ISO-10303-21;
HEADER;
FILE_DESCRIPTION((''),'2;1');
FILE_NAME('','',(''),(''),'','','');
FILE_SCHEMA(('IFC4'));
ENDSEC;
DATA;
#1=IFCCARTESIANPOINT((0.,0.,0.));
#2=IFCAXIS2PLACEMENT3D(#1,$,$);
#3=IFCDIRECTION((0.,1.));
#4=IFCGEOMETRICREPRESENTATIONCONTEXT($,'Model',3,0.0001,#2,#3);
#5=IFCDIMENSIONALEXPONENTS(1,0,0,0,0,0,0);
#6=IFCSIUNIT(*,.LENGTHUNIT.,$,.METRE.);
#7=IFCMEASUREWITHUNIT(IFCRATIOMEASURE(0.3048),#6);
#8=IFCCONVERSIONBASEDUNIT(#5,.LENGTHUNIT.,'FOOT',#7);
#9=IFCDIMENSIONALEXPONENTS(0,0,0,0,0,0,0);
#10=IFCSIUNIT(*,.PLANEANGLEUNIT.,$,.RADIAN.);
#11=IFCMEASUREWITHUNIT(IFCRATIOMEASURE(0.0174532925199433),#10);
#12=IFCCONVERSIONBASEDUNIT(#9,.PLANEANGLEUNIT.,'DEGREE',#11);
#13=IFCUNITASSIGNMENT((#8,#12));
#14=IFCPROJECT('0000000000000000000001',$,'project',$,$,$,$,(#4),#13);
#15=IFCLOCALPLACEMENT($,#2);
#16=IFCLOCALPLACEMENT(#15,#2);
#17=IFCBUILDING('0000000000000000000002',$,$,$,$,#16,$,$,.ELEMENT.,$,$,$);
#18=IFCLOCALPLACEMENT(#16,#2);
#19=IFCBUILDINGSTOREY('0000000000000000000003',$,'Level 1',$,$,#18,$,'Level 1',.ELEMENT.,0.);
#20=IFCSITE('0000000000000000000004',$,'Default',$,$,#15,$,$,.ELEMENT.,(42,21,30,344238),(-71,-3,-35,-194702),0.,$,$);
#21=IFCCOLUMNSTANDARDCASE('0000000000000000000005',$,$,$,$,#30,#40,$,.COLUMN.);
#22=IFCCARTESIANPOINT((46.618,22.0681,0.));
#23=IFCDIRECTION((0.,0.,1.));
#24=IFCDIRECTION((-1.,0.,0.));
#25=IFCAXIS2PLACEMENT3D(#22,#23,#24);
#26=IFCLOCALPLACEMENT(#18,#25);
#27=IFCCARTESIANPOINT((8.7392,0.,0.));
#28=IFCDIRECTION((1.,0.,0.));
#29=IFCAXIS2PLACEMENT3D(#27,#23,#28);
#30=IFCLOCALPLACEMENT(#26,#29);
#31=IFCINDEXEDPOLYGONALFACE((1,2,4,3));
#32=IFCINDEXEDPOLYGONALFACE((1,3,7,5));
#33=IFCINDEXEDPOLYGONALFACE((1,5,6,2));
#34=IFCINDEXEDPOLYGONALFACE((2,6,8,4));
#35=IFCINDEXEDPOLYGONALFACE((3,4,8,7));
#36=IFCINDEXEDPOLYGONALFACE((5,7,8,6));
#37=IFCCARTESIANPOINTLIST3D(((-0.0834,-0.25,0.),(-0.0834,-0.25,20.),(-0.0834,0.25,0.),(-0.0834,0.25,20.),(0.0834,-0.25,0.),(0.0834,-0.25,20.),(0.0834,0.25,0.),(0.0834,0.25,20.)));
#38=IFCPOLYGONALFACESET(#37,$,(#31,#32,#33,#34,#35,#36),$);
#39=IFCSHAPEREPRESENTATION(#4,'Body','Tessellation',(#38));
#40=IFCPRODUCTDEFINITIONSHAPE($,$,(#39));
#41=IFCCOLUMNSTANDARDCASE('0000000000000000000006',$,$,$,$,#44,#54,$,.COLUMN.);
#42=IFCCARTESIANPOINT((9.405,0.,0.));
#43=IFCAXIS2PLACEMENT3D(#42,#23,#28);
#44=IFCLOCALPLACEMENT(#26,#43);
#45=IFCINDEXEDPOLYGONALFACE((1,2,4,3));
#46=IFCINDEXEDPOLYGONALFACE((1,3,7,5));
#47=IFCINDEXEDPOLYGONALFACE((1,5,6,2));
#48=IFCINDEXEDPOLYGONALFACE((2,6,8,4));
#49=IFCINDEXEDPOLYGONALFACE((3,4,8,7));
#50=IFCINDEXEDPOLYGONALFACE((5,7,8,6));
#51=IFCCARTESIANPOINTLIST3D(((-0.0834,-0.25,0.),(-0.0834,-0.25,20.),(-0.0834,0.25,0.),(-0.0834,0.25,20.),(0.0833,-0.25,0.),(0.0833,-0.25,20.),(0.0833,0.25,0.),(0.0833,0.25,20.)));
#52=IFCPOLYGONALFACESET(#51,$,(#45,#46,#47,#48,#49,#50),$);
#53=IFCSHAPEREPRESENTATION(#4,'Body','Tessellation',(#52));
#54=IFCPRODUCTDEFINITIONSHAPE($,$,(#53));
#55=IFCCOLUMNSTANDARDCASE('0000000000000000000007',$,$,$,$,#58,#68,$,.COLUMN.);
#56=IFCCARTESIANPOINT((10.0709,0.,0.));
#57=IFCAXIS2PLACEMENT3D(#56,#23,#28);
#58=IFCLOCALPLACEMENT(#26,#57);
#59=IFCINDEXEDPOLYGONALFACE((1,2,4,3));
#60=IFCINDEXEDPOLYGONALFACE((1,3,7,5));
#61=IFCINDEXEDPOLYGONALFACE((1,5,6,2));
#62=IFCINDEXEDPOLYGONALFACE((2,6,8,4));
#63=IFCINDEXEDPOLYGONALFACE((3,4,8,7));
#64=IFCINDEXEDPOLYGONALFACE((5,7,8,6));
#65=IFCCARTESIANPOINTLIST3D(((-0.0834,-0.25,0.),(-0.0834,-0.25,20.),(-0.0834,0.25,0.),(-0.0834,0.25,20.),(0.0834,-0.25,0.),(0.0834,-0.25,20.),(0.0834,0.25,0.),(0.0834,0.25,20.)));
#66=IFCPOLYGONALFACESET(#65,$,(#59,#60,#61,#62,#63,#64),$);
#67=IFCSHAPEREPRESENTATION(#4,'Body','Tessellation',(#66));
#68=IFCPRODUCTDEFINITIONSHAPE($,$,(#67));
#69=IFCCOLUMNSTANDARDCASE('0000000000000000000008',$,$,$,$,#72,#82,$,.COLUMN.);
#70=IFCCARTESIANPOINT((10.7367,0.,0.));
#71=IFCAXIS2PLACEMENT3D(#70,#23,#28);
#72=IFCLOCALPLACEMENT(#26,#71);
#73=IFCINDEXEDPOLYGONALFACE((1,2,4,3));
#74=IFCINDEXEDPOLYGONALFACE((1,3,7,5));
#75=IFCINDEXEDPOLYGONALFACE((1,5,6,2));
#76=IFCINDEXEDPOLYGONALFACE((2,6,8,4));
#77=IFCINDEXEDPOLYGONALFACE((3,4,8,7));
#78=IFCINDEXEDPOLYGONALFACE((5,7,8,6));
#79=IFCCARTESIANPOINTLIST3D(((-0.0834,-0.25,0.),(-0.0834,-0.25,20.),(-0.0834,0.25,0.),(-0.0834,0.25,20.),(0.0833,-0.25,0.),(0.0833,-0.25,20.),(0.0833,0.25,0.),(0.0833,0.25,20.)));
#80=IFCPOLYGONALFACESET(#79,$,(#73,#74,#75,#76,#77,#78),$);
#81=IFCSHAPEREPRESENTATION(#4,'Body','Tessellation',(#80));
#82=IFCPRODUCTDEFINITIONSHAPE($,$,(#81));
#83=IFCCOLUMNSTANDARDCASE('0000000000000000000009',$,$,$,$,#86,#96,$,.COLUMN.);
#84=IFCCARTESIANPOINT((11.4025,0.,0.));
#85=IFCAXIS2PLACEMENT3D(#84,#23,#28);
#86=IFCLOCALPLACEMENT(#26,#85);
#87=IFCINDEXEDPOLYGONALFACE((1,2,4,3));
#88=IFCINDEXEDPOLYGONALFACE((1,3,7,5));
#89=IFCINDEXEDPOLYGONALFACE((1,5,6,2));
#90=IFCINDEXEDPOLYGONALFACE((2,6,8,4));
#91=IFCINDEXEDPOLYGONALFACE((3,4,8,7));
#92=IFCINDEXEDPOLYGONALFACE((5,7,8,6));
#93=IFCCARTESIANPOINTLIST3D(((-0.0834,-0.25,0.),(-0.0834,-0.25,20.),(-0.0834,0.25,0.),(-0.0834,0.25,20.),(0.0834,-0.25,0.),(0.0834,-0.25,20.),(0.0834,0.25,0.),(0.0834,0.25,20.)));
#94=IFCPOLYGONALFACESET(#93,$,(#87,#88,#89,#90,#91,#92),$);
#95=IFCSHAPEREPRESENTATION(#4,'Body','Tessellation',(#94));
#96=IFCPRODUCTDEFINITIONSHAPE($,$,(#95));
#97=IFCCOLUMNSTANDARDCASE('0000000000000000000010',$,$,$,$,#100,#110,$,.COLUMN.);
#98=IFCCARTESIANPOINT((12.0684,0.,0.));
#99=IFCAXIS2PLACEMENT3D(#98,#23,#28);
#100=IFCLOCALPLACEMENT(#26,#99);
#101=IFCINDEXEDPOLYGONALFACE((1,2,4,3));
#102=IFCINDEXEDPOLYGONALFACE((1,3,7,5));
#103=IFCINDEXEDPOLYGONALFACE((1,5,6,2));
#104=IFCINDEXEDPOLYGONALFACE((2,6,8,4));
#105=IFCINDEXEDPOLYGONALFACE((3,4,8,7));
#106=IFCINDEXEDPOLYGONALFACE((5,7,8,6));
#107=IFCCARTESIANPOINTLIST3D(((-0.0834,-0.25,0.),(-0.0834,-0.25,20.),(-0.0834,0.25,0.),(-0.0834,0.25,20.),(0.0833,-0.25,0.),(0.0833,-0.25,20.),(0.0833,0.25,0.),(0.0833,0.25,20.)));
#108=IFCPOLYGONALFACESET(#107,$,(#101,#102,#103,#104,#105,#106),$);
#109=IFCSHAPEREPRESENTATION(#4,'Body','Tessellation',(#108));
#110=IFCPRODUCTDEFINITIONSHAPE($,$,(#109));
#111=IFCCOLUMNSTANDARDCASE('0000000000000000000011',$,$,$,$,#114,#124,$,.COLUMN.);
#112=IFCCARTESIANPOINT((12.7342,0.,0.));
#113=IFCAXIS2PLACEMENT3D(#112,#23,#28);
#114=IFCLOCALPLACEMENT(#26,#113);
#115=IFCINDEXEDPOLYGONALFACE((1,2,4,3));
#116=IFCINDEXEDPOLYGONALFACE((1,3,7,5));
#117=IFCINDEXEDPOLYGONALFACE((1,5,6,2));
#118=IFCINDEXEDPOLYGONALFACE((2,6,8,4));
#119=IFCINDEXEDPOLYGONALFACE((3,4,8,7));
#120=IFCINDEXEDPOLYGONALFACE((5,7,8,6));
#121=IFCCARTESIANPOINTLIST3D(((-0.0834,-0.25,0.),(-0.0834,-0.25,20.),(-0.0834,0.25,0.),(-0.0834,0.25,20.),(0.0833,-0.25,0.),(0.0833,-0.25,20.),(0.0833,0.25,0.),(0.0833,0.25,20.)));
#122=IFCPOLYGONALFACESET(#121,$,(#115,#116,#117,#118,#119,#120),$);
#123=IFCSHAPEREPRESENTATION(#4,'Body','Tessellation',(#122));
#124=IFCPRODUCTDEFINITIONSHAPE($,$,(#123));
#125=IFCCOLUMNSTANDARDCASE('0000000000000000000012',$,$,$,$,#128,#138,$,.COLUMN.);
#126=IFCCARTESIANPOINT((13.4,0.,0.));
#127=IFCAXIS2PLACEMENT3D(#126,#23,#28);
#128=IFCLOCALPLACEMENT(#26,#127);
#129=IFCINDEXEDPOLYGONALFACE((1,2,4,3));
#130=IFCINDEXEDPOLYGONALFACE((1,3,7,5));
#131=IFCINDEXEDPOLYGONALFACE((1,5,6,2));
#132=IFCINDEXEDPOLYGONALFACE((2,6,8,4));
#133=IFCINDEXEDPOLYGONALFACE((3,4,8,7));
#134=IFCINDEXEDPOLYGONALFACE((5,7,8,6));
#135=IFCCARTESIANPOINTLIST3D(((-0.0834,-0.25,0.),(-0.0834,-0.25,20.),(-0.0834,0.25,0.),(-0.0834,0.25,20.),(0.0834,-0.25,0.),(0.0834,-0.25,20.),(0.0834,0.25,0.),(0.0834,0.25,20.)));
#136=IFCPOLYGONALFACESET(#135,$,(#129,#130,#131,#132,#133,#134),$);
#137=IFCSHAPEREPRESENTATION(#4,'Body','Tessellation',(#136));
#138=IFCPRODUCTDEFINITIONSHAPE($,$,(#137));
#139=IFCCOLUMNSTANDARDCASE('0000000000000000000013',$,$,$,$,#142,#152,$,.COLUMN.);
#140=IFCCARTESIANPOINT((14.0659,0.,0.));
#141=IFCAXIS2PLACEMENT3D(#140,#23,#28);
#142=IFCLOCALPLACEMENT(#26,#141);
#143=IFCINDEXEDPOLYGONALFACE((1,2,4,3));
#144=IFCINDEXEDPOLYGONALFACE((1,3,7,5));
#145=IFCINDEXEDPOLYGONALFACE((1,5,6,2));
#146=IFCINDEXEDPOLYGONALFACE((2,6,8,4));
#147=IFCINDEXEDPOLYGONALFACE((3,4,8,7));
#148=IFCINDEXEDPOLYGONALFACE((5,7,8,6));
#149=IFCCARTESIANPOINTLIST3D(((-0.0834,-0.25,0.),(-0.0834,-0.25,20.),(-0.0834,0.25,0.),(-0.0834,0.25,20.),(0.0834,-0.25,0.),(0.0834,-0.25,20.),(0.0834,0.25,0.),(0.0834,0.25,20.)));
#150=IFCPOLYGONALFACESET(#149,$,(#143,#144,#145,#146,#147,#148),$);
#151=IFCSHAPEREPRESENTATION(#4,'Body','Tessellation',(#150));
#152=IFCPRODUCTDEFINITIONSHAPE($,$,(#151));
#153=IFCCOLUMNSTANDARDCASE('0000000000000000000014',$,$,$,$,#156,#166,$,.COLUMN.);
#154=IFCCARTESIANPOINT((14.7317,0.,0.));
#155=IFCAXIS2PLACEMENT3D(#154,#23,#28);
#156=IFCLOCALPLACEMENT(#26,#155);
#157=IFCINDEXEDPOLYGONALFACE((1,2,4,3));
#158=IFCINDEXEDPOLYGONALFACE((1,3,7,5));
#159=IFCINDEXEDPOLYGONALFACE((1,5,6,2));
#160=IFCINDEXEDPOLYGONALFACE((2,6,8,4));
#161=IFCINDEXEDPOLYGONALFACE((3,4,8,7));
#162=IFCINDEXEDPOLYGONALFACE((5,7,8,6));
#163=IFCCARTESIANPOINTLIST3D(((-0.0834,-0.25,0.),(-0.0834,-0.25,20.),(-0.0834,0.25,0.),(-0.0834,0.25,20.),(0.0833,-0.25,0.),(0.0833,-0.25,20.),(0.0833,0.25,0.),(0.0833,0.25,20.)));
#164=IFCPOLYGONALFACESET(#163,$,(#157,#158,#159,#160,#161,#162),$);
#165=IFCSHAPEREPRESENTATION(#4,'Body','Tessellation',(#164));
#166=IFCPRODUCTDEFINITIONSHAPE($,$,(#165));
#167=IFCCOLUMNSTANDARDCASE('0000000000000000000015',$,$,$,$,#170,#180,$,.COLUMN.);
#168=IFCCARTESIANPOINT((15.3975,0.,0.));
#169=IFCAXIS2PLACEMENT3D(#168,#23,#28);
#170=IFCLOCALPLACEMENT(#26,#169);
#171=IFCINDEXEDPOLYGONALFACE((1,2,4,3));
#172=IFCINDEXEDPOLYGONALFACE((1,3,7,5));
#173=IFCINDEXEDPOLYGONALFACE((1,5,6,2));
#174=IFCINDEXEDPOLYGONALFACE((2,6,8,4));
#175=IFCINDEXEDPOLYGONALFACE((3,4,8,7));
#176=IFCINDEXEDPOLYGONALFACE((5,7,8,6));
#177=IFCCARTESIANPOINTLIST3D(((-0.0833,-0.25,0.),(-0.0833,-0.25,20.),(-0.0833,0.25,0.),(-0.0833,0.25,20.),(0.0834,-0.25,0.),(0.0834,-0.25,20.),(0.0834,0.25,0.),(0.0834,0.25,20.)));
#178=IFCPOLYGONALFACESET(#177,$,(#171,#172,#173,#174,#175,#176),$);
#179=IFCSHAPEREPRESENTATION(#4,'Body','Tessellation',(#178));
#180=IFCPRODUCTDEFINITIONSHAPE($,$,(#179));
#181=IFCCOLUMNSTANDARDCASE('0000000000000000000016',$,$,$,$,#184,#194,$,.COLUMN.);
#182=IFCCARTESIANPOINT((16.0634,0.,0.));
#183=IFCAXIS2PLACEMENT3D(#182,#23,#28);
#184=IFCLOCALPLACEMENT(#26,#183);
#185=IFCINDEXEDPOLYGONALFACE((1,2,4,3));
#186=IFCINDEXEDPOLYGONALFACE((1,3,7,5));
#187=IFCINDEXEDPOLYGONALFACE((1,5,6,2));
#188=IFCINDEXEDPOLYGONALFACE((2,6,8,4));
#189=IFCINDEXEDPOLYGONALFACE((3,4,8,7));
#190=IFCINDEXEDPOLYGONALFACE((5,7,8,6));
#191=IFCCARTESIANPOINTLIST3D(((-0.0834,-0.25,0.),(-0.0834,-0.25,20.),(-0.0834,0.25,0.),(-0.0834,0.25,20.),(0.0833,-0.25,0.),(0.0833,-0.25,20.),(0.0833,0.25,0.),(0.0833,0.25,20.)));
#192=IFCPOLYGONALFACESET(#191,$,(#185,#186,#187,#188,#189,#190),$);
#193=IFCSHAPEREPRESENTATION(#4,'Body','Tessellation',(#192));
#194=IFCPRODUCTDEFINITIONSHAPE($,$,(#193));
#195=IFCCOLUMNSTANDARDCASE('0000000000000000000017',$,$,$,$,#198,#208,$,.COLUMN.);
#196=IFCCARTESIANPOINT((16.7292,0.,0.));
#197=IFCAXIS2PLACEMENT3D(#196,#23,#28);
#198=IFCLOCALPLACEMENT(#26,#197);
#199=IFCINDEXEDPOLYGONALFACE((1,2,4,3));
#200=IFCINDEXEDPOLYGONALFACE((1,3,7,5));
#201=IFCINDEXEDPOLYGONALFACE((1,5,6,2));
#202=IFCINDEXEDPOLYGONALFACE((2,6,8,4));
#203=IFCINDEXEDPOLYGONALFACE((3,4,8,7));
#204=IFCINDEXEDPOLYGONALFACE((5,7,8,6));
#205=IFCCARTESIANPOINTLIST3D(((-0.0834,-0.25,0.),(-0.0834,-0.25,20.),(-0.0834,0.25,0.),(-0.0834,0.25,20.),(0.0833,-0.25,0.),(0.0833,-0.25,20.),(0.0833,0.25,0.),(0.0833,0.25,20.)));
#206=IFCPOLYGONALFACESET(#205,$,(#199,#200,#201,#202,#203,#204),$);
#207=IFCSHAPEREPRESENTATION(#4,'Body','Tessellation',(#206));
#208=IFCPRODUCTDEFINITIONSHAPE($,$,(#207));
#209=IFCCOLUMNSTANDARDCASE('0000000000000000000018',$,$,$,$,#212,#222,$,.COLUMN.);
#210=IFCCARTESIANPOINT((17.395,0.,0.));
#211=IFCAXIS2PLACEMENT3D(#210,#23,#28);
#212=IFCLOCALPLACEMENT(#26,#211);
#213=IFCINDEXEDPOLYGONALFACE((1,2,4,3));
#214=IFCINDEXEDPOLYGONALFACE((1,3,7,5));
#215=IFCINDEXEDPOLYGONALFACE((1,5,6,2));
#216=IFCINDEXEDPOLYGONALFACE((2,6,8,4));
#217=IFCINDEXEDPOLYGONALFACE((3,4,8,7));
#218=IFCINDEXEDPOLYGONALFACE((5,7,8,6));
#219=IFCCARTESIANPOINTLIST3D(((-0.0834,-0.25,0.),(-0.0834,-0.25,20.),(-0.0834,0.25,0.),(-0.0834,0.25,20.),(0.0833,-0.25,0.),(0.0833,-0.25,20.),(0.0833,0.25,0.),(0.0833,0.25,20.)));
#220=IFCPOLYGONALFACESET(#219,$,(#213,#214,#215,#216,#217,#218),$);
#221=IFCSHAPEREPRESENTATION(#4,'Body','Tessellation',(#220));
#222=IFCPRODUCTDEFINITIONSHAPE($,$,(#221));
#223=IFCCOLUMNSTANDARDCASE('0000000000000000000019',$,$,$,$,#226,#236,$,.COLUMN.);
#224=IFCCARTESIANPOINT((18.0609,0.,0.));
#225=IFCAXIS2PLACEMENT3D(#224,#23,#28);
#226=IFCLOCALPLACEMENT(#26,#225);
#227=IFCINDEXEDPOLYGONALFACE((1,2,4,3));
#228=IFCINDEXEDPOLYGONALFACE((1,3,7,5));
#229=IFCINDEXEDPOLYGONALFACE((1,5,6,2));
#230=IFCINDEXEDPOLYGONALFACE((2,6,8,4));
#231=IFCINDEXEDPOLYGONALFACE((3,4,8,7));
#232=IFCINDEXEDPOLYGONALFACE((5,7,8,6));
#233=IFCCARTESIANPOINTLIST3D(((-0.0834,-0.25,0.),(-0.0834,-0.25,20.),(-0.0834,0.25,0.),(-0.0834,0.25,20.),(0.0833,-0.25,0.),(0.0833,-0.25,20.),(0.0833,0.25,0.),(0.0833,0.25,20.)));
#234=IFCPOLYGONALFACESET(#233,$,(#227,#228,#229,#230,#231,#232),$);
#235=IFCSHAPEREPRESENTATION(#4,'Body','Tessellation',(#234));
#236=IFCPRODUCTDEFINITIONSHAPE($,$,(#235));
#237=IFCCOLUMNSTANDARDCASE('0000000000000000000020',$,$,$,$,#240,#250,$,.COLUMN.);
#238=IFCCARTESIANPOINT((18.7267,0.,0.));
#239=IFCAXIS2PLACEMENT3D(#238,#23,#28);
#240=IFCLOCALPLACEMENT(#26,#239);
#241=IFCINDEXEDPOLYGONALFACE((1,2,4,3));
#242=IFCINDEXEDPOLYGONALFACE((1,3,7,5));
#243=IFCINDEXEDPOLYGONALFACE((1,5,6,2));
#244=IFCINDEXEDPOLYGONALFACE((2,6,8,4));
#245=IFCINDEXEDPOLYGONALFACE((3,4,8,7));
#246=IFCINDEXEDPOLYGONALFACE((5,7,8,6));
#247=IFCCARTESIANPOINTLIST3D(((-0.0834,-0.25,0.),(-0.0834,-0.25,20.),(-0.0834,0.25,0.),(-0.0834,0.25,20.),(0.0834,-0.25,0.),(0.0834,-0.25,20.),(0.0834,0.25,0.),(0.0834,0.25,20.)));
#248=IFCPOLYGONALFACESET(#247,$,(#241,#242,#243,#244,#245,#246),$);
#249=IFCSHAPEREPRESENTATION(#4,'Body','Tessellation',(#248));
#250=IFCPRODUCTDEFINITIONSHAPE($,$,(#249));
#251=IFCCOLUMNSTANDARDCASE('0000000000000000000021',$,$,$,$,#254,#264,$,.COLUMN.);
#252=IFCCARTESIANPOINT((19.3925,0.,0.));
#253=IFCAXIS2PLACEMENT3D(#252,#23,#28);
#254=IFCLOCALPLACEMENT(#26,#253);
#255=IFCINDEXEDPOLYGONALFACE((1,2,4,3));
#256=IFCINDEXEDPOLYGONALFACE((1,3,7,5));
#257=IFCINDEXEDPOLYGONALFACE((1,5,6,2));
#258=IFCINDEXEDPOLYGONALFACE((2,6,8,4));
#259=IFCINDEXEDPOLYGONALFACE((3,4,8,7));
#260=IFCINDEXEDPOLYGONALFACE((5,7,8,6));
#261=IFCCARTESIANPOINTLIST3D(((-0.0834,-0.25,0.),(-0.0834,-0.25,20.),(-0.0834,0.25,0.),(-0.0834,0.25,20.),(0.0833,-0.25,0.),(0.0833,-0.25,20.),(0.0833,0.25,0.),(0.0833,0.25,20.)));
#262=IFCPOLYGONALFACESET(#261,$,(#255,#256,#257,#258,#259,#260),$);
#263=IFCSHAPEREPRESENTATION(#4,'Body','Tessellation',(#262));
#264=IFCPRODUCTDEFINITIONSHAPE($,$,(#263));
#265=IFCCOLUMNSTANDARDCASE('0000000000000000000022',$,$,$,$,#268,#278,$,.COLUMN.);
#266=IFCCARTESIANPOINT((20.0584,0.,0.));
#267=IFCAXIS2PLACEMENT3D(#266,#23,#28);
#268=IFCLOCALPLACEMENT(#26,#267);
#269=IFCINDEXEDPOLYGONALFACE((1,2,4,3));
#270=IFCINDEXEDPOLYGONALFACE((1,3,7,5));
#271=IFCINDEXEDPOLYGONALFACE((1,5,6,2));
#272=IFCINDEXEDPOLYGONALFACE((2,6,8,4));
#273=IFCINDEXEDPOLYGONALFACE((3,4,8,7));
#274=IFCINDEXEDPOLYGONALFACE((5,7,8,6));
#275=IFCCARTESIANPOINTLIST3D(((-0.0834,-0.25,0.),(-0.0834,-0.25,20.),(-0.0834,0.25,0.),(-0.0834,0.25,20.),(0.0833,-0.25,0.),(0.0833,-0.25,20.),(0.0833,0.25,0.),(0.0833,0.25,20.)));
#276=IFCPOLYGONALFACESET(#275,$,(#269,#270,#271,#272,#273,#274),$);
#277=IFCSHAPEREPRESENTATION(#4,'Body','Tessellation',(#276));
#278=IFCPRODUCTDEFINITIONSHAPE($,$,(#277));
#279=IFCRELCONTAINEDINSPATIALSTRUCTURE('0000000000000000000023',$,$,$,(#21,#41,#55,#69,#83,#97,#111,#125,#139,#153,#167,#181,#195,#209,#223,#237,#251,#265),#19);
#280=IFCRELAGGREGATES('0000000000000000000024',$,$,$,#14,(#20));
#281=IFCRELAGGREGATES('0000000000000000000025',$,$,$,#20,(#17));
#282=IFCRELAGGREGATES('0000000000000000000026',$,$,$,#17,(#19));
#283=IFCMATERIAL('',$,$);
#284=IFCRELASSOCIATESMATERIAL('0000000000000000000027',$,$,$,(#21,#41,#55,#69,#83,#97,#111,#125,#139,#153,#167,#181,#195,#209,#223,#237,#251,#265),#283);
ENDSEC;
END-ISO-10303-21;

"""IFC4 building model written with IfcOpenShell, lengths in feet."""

from ifc_helpers import new_model, entity, si_unit, converted_unit, direction, frame, origin, place, context, project, spatial, rectangle, extrude, material, element, save


model = new_model("IFC4")

# Units and contexts
model_context = context("Model", 3, precision=0.0001, world=origin(), true_north=direction((0.0, 1.0)))
ifc_project = project(units=[converted_unit("LENGTHUNIT", "FOOT", entity("IfcRatioMeasure", 0.3048), si_unit("LENGTHUNIT", "METRE"), dimensions=[1, 0, 0, 0, 0, 0, 0]), converted_unit("PLANEANGLEUNIT", "DEGREE", entity("IfcRatioMeasure", 0.0174532925199433), si_unit("PLANEANGLEUNIT", "RADIAN"), dimensions=[0, 0, 0, 0, 0, 0, 0])], contexts=[model_context])

# Site, building, storey
site_placement = place(None, origin())
site = spatial("IfcSite", under=ifc_project, at=site_placement, Name="Default", CompositionType="ELEMENT", RefLatitude=(42, 21, 30, 344238), RefLongitude=(-71, -3, -35, -194702), RefElevation=0.0)
building_placement = place(site_placement, origin())
building = spatial("IfcBuilding", under=site, at=building_placement, CompositionType="ELEMENT")
storey_placement = place(building_placement, origin())
storey = spatial("IfcBuildingStorey", under=building, at=storey_placement, Name="Level 1", LongName="Level 1", CompositionType="ELEMENT", Elevation=0.0)

# Columns
ifc_material = material(Name="")
placement = place(storey_placement, frame((46.618, 22.0681, 0.0), z_axis=(0.0, 0.0, 1.0), x_axis=(-1.0, 0.0, 0.0)))
for number, where, z_axis, x_axis in (
    (1, (8.7392, 0.0, 0.0), (0.0, 0.0, 1.0), (1.0, 0.0, 0.0)),
    (2, (9.405, 0.0, 0.0), (0.0, 0.0, 1.0), (1.0, 0.0, 0.0)),
    (3, (10.0709, 0.0, 0.0), (0.0, 0.0, 1.0), (1.0, 0.0, 0.0)),
    (4, (10.7367, 0.0, 0.0), (0.0, 0.0, 1.0), (1.0, 0.0, 0.0)),
    (5, (11.4025, 0.0, 0.0), (0.0, 0.0, 1.0), (1.0, 0.0, 0.0)),
    (6, (12.0684, 0.0, 0.0), (0.0, 0.0, 1.0), (1.0, 0.0, 0.0)),
    (7, (12.7342, 0.0, 0.0), (0.0, 0.0, 1.0), (1.0, 0.0, 0.0)),
    (8, (13.4, 0.0, 0.0), (0.0, 0.0, 1.0), (1.0, 0.0, 0.0)),
    (9, (14.0659, 0.0, 0.0), (0.0, 0.0, 1.0), (1.0, 0.0, 0.0)),
    (10, (14.7317, 0.0, 0.0), (0.0, 0.0, 1.0), (1.0, 0.0, 0.0)),
    (11, (15.3975, 0.0, 0.0), (0.0, 0.0, 1.0), (1.0, 0.0, 0.0)),
    (12, (16.0634, 0.0, 0.0), (0.0, 0.0, 1.0), (1.0, 0.0, 0.0)),
    (13, (16.7292, 0.0, 0.0), (0.0, 0.0, 1.0), (1.0, 0.0, 0.0)),
    (14, (17.395, 0.0, 0.0), (0.0, 0.0, 1.0), (1.0, 0.0, 0.0)),
    (15, (18.0609, 0.0, 0.0), (0.0, 0.0, 1.0), (1.0, 0.0, 0.0)),
    (16, (18.7267, 0.0, 0.0), (0.0, 0.0, 1.0), (1.0, 0.0, 0.0)),
    (17, (19.3925, 0.0, 0.0), (0.0, 0.0, 1.0), (1.0, 0.0, 0.0)),
    (18, (20.0584, 0.0, 0.0), (0.0, 0.0, 1.0), (1.0, 0.0, 0.0)),
):
    element("IfcColumnStandardCase", number, at=place(placement, frame(where, z_axis=z_axis, x_axis=x_axis)), inside=storey, material=ifc_material, PredefinedType="COLUMN", context=model_context, shape_type="SweptSolid", body=[
        extrude(rectangle(XDim=0.1667, YDim=0.5), origin(), (0.0, 0.0, 1.0), 20.0),
    ])

save(model, "model.ifc")
